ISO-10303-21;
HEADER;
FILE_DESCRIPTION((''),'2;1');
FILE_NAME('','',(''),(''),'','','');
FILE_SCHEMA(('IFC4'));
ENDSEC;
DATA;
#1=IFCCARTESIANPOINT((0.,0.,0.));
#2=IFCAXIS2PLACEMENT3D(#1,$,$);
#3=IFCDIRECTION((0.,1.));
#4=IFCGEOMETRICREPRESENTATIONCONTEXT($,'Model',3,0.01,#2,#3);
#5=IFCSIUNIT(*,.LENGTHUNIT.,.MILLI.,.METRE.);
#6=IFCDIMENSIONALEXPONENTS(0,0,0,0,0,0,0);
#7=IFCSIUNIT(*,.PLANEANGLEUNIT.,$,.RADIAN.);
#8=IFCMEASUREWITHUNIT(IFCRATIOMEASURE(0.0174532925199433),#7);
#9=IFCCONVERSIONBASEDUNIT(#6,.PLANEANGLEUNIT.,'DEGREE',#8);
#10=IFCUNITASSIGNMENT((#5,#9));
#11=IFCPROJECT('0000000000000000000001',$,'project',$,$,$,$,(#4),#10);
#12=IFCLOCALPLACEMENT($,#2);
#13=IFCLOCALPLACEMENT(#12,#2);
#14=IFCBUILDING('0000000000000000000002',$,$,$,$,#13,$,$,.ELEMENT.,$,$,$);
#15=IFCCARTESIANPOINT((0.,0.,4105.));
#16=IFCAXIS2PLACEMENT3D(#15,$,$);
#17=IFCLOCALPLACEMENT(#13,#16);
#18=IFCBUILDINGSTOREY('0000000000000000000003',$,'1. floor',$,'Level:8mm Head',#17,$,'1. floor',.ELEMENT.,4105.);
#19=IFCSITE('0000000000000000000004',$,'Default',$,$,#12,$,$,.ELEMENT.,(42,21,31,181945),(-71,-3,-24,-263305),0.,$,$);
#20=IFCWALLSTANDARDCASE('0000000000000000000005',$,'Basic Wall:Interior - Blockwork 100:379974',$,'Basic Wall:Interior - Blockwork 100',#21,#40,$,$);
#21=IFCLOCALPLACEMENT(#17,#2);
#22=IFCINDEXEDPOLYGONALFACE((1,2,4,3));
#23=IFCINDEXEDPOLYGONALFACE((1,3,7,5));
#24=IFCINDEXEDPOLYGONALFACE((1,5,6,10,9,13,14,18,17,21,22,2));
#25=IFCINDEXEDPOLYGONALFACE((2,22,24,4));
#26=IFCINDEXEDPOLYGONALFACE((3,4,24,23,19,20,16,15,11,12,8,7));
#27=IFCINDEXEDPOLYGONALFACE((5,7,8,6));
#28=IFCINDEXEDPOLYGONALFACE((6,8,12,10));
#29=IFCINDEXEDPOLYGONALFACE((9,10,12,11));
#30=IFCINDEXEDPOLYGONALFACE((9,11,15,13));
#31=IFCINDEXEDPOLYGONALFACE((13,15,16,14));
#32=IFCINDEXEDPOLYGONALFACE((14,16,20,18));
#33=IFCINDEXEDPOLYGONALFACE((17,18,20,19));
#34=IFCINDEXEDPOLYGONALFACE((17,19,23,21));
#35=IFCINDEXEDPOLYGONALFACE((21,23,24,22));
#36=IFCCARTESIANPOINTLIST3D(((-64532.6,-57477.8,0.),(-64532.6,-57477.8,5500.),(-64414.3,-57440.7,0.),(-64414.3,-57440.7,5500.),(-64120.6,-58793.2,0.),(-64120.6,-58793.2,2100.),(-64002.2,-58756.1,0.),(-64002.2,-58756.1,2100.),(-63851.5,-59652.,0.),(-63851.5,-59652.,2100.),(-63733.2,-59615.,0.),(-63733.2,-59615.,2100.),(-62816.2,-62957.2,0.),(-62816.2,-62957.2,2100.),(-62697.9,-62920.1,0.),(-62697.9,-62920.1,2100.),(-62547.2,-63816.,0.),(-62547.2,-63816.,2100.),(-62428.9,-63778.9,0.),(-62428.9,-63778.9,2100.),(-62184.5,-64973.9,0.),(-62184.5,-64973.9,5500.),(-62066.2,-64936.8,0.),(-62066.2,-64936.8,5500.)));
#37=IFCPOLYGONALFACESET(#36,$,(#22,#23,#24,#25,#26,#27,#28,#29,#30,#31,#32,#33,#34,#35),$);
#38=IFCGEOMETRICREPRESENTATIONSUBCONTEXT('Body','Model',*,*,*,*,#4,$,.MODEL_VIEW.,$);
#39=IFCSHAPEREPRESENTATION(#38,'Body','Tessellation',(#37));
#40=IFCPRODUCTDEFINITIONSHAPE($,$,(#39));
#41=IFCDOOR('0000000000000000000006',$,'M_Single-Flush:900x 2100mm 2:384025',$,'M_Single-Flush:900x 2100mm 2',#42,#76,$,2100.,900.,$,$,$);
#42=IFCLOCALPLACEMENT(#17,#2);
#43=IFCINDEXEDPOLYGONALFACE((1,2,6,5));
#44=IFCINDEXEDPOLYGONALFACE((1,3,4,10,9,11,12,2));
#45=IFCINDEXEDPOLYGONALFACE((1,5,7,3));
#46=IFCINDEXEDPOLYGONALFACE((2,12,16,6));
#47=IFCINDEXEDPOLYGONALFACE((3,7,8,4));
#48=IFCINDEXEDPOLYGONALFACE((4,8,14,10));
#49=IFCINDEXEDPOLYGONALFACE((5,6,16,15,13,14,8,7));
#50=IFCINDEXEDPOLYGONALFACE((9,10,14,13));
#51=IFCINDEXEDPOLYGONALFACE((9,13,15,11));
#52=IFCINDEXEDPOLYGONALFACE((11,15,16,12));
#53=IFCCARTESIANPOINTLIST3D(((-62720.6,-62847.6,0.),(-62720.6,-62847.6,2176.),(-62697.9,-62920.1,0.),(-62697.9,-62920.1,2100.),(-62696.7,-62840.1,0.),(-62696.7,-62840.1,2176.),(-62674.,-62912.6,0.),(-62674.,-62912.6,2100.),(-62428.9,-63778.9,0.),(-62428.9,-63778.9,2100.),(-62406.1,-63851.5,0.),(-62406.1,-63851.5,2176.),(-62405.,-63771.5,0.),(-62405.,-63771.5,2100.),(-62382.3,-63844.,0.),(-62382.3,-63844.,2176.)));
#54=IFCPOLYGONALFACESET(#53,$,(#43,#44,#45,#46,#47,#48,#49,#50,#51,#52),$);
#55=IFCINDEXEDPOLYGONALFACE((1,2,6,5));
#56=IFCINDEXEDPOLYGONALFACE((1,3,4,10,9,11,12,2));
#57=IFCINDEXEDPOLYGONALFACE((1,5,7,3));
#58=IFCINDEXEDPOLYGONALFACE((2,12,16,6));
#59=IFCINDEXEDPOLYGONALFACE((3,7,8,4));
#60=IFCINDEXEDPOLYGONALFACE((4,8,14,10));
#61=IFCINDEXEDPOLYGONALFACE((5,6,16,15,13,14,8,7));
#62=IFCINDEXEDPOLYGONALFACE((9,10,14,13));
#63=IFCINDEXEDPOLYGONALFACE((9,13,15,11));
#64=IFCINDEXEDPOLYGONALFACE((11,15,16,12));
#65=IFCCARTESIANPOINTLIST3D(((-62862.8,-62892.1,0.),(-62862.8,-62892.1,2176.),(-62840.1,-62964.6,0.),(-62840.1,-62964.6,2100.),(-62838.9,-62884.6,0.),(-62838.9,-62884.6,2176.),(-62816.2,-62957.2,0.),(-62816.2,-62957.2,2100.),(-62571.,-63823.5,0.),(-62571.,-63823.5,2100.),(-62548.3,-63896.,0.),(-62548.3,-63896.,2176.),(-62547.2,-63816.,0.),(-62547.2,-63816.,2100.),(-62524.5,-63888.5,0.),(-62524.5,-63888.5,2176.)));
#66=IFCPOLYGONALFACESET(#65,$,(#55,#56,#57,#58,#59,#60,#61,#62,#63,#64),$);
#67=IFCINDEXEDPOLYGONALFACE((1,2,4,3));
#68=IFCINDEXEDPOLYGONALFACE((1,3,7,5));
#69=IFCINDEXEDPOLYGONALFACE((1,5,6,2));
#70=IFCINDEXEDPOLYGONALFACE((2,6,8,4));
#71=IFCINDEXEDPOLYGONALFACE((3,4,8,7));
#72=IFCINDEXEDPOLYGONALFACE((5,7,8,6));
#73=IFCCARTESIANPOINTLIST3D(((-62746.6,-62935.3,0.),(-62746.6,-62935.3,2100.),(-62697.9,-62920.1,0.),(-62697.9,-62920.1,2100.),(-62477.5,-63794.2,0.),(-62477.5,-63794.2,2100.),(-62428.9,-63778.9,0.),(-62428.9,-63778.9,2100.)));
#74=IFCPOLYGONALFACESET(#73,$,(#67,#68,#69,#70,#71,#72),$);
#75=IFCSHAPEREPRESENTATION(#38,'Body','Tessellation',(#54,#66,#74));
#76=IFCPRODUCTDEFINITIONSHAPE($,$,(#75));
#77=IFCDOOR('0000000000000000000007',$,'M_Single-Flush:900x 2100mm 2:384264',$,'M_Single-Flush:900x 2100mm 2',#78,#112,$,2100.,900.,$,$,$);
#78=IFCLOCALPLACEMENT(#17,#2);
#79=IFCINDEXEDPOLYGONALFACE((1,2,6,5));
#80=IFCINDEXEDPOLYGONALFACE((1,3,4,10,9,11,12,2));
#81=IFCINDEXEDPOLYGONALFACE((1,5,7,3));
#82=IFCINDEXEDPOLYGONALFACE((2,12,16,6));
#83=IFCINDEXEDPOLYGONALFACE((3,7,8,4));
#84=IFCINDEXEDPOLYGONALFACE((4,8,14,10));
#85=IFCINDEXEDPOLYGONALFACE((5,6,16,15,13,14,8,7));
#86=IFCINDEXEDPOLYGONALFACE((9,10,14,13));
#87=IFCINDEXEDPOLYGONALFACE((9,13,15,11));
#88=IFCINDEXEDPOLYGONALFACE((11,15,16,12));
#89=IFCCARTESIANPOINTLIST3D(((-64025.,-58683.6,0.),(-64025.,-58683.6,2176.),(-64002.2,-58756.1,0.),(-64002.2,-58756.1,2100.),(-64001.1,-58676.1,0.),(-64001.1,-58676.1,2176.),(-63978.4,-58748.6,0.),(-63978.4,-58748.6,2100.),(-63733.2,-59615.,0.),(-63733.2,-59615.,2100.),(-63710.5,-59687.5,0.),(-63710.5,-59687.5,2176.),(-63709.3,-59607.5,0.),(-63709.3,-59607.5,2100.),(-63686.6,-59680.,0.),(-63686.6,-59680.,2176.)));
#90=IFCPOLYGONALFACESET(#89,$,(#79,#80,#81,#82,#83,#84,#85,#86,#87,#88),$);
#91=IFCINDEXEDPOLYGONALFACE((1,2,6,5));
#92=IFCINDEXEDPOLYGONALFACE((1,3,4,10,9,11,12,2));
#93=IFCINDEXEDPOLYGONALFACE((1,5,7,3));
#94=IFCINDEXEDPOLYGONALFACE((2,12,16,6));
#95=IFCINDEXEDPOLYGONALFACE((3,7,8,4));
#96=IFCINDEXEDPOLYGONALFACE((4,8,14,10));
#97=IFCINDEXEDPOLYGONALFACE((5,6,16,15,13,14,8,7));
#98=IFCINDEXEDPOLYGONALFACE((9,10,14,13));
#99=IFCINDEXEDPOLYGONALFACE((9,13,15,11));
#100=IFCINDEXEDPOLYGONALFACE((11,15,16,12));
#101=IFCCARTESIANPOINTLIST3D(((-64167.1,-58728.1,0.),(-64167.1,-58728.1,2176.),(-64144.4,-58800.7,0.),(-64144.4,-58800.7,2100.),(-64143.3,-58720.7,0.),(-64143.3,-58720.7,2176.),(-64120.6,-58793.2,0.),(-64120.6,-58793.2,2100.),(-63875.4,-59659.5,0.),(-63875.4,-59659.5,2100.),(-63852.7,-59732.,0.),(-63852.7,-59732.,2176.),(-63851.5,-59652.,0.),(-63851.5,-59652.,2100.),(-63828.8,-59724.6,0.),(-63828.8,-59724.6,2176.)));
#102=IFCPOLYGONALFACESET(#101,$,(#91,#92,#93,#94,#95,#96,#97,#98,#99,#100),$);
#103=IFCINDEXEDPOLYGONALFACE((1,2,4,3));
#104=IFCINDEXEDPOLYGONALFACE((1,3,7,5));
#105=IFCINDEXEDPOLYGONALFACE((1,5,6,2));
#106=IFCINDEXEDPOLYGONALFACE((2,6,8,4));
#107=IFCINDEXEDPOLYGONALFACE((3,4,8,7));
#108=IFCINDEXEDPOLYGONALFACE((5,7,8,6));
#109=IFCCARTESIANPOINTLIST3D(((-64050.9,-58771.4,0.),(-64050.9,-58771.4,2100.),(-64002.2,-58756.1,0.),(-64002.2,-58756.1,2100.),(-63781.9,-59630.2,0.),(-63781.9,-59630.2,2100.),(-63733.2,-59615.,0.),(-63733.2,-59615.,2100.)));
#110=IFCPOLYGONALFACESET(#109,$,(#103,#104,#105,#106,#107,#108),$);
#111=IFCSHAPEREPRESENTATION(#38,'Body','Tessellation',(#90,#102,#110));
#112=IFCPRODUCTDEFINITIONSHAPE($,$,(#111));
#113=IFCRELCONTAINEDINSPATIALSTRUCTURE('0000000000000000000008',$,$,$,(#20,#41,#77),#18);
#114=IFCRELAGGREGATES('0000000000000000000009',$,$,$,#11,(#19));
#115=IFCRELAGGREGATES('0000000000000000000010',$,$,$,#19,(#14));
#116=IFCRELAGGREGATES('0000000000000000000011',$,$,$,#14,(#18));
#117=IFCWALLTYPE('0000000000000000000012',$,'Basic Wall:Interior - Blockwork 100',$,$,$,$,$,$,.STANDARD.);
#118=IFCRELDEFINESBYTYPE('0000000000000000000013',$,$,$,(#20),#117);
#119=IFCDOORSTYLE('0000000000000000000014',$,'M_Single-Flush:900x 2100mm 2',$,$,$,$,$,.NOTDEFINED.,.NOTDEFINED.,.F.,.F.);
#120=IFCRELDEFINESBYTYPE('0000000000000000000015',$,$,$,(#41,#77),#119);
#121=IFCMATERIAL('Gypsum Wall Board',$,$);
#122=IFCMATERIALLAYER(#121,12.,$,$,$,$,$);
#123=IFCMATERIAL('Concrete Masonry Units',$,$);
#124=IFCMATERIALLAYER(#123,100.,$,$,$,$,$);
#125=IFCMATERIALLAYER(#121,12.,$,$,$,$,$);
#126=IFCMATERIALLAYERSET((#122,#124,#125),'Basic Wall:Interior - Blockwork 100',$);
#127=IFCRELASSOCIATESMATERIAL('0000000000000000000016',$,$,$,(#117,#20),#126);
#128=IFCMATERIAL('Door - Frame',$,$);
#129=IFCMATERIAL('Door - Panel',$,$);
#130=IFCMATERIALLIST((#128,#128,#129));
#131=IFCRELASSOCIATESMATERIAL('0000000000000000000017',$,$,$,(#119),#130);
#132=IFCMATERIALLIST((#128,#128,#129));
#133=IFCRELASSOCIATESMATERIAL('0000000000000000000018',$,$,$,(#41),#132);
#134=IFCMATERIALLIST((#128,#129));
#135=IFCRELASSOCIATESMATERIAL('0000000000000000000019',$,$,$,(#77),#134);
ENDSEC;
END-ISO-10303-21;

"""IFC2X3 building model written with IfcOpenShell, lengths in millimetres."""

from ifc_helpers import new_model, entity, si_unit, converted_unit, direction, frame, frame_2d, origin, origin_2d_with_axis, place, context, subcontext, project, spatial, polyline, rectangle, outline, extrude, source, transform, mapped, material, material_list, layer, layer_set, layer_usage, type_object, type_shapes, element, fill, save


model = new_model("IFC2X3")

# Units and contexts
model_context = context("Model", 3, precision=0.01, world=origin(), true_north=direction((0.0, 1.0)))
body_context = subcontext(model_context, "Body", "Model", "MODEL_VIEW")
ifc_project = project(units=[si_unit("LENGTHUNIT", "METRE", prefix="MILLI"), converted_unit("PLANEANGLEUNIT", "DEGREE", entity("IfcRatioMeasure", 0.0174532925199433), si_unit("PLANEANGLEUNIT", "RADIAN"), dimensions=[0, 0, 0, 0, 0, 0, 0])], contexts=[model_context])

# Site, building, storey
site_placement = place(None, origin())
site = spatial("IfcSite", under=ifc_project, at=site_placement, Name="Default", CompositionType="ELEMENT", RefLatitude=(42, 21, 31, 181945), RefLongitude=(-71, -3, -24, -263305), RefElevation=0.0)
building_placement = place(site_placement, origin())
building = spatial("IfcBuilding", under=site, at=building_placement, CompositionType="ELEMENT")
storey_placement = place(building_placement, frame((0.0, 0.0, 4105.0)))
storey = spatial("IfcBuildingStorey", under=building, at=storey_placement, Name="1. floor", ObjectType="Level:8mm Head", LongName="1. floor", CompositionType="ELEMENT", Elevation=4105.0)

# Shared definitions
ifc_material_1 = material(Name="Gypsum Wall Board")

# Shared definitions
ifc_layer_1 = layer(ifc_material_1, 12.0)
ifc_material_2 = material(Name="Concrete Masonry Units")
ifc_layer_2 = layer(ifc_material_2, 100.0)
ifc_layer_3 = layer(ifc_material_1, 12.0)
ifc_layer_set_1 = layer_set([ifc_layer_1, ifc_layer_2, ifc_layer_3], Name="Basic Wall:Interior - Blockwork 100")
wall_type_1 = type_object("IfcWallType", Name="Basic Wall:Interior - Blockwork 100", PredefinedType="STANDARD", material=ifc_layer_set_1)
ifc_material_3 = material(Name="Door - Frame")
ifc_material_4 = material(Name="Door - Panel")
ifc_material_list_1 = material_list([ifc_material_3, ifc_material_3, ifc_material_4])
door_style_1 = type_object("IfcDoorStyle", Name="M_Single-Flush:900x 2100mm 2", ConstructionType="NOTDEFINED", OperationType="NOTDEFINED", ParameterTakesPrecedence=False, Sizeable=False, material=ifc_material_list_1)
shared_shape_1 = source(origin(), body_context, "Body", "SweptSolid", [
    extrude(outline(polyline([(-526.0, -1107.0), (526.0, -1107.0), (526.0, 1069.0), (450.0, 1069.0), (450.0, -1031.0), (-450.0, -1031.0), (-450.0, 1069.0), (-526.0, 1069.0), (-526.0, -1107.0)])), frame((450.0, 124.0, 1069.0), z_axis=(0.0, 1.0, 0.0), x_axis=(1.0, 0.0, 0.0)), (0.0, 0.0, 1.0), 25.0),
    extrude(outline(polyline([(-1107.0, -526.0), (1069.0, -526.0), (1069.0, -450.0), (-1031.0, -450.0), (-1031.0, 450.0), (1069.0, 450.0), (1069.0, 526.0), (-1107.0, 526.0), (-1107.0, -526.0)])), frame((450.0, -25.0, 1069.0), z_axis=(0.0, 1.0, 0.0), x_axis=(0.0, 0.0, -1.0)), (0.0, 0.0, 1.0), 25.0),
    extrude(rectangle(XDim=51.0, YDim=900.0, at=origin_2d_with_axis()), frame((450.0, 98.5, 0.0), z_axis=(0.0, 0.0, 1.0), x_axis=(0.0, 1.0, 0.0)), (0.0, 0.0, 1.0), 2100.0),
])
type_shapes(door_style_1, [shared_shape_1])

# Wall, openings, doors
ifc_layer_usage_1 = layer_usage(ifc_layer_set_1, "AXIS2", "NEGATIVE", 62.0)
wall_1_placement = place(storey_placement, frame((-64473.4, -57459.3, 0.0), z_axis=(0.0, 0.0, 1.0), x_axis=(0.298924, -0.954277, 0.0)))
wall_1 = element("IfcWallStandardCase", 1, at=wall_1_placement, inside=storey, type_object=wall_type_1, material=ifc_layer_usage_1, Name="Basic Wall:Interior - Blockwork 100:379974", ObjectType="Basic Wall:Interior - Blockwork 100", context=body_context, shape_type="SweptSolid", body=[
    extrude(rectangle(XDim=7855.2, YDim=124.0, at=frame_2d((3927.6, 0.0), x_axis=(-1.0, 0.0))), origin(), (0.0, 0.0, 1.0), 5500.0),
])
opening_1_placement = place(wall_1_placement, frame((5741.9, -62.0, 0.0)))
opening_1 = element("IfcOpeningElement", 2, at=opening_1_placement, cuts=wall_1, ObjectType="Opening", context=body_context, shape_type="SweptSolid", body=[
    extrude(rectangle(XDim=900.0, YDim=2100.0, at=frame_2d((1050.0, 450.0), x_axis=(0.0, 1.0))), frame((0.0, 0.0, 0.0), z_axis=(0.0, 1.0, 0.0), x_axis=(0.0, 0.0, 1.0)), (0.0, 0.0, 1.0), 124.0),
])
opening_2_placement = place(wall_1_placement, frame((1378.4, -62.0, 0.0)))
opening_2 = element("IfcOpeningElement", 3, at=opening_2_placement, cuts=wall_1, ObjectType="Opening", context=body_context, shape_type="SweptSolid", body=[
    extrude(rectangle(XDim=900.0, YDim=2100.0, at=frame_2d((1050.0, 450.0), x_axis=(0.0, 1.0))), frame((0.0, 0.0, 0.0), z_axis=(0.0, 1.0, 0.0), x_axis=(0.0, 0.0, 1.0)), (0.0, 0.0, 1.0), 124.0),
])
ifc_material_list_2 = material_list([ifc_material_3, ifc_material_3, ifc_material_4])
door_1_placement = place(opening_1_placement, origin())
door_1 = element("IfcDoor", 4, at=door_1_placement, inside=storey, type_object=door_style_1, material=ifc_material_list_2, Name="M_Single-Flush:900x 2100mm 2:384025", ObjectType="M_Single-Flush:900x 2100mm 2", OverallHeight=2100.0, OverallWidth=900.0, context=body_context, shape_type="MappedRepresentation", body=[
    mapped(shared_shape_1, transform((0.0, 0.0, 0.0), scale=1.0)),
])
fill(opening_1, door_1)
ifc_material_list_3 = material_list([ifc_material_3, ifc_material_4])
door_2_placement = place(opening_2_placement, origin())
door_2 = element("IfcDoor", 5, at=door_2_placement, inside=storey, type_object=door_style_1, material=ifc_material_list_3, Name="M_Single-Flush:900x 2100mm 2:384264", ObjectType="M_Single-Flush:900x 2100mm 2", OverallHeight=2100.0, OverallWidth=900.0, context=body_context, shape_type="MappedRepresentation", body=[
    mapped(shared_shape_1, transform((0.0, 0.0, 0.0), scale=1.0)),
])
fill(opening_2, door_2)

save(model, "model.ifc")
